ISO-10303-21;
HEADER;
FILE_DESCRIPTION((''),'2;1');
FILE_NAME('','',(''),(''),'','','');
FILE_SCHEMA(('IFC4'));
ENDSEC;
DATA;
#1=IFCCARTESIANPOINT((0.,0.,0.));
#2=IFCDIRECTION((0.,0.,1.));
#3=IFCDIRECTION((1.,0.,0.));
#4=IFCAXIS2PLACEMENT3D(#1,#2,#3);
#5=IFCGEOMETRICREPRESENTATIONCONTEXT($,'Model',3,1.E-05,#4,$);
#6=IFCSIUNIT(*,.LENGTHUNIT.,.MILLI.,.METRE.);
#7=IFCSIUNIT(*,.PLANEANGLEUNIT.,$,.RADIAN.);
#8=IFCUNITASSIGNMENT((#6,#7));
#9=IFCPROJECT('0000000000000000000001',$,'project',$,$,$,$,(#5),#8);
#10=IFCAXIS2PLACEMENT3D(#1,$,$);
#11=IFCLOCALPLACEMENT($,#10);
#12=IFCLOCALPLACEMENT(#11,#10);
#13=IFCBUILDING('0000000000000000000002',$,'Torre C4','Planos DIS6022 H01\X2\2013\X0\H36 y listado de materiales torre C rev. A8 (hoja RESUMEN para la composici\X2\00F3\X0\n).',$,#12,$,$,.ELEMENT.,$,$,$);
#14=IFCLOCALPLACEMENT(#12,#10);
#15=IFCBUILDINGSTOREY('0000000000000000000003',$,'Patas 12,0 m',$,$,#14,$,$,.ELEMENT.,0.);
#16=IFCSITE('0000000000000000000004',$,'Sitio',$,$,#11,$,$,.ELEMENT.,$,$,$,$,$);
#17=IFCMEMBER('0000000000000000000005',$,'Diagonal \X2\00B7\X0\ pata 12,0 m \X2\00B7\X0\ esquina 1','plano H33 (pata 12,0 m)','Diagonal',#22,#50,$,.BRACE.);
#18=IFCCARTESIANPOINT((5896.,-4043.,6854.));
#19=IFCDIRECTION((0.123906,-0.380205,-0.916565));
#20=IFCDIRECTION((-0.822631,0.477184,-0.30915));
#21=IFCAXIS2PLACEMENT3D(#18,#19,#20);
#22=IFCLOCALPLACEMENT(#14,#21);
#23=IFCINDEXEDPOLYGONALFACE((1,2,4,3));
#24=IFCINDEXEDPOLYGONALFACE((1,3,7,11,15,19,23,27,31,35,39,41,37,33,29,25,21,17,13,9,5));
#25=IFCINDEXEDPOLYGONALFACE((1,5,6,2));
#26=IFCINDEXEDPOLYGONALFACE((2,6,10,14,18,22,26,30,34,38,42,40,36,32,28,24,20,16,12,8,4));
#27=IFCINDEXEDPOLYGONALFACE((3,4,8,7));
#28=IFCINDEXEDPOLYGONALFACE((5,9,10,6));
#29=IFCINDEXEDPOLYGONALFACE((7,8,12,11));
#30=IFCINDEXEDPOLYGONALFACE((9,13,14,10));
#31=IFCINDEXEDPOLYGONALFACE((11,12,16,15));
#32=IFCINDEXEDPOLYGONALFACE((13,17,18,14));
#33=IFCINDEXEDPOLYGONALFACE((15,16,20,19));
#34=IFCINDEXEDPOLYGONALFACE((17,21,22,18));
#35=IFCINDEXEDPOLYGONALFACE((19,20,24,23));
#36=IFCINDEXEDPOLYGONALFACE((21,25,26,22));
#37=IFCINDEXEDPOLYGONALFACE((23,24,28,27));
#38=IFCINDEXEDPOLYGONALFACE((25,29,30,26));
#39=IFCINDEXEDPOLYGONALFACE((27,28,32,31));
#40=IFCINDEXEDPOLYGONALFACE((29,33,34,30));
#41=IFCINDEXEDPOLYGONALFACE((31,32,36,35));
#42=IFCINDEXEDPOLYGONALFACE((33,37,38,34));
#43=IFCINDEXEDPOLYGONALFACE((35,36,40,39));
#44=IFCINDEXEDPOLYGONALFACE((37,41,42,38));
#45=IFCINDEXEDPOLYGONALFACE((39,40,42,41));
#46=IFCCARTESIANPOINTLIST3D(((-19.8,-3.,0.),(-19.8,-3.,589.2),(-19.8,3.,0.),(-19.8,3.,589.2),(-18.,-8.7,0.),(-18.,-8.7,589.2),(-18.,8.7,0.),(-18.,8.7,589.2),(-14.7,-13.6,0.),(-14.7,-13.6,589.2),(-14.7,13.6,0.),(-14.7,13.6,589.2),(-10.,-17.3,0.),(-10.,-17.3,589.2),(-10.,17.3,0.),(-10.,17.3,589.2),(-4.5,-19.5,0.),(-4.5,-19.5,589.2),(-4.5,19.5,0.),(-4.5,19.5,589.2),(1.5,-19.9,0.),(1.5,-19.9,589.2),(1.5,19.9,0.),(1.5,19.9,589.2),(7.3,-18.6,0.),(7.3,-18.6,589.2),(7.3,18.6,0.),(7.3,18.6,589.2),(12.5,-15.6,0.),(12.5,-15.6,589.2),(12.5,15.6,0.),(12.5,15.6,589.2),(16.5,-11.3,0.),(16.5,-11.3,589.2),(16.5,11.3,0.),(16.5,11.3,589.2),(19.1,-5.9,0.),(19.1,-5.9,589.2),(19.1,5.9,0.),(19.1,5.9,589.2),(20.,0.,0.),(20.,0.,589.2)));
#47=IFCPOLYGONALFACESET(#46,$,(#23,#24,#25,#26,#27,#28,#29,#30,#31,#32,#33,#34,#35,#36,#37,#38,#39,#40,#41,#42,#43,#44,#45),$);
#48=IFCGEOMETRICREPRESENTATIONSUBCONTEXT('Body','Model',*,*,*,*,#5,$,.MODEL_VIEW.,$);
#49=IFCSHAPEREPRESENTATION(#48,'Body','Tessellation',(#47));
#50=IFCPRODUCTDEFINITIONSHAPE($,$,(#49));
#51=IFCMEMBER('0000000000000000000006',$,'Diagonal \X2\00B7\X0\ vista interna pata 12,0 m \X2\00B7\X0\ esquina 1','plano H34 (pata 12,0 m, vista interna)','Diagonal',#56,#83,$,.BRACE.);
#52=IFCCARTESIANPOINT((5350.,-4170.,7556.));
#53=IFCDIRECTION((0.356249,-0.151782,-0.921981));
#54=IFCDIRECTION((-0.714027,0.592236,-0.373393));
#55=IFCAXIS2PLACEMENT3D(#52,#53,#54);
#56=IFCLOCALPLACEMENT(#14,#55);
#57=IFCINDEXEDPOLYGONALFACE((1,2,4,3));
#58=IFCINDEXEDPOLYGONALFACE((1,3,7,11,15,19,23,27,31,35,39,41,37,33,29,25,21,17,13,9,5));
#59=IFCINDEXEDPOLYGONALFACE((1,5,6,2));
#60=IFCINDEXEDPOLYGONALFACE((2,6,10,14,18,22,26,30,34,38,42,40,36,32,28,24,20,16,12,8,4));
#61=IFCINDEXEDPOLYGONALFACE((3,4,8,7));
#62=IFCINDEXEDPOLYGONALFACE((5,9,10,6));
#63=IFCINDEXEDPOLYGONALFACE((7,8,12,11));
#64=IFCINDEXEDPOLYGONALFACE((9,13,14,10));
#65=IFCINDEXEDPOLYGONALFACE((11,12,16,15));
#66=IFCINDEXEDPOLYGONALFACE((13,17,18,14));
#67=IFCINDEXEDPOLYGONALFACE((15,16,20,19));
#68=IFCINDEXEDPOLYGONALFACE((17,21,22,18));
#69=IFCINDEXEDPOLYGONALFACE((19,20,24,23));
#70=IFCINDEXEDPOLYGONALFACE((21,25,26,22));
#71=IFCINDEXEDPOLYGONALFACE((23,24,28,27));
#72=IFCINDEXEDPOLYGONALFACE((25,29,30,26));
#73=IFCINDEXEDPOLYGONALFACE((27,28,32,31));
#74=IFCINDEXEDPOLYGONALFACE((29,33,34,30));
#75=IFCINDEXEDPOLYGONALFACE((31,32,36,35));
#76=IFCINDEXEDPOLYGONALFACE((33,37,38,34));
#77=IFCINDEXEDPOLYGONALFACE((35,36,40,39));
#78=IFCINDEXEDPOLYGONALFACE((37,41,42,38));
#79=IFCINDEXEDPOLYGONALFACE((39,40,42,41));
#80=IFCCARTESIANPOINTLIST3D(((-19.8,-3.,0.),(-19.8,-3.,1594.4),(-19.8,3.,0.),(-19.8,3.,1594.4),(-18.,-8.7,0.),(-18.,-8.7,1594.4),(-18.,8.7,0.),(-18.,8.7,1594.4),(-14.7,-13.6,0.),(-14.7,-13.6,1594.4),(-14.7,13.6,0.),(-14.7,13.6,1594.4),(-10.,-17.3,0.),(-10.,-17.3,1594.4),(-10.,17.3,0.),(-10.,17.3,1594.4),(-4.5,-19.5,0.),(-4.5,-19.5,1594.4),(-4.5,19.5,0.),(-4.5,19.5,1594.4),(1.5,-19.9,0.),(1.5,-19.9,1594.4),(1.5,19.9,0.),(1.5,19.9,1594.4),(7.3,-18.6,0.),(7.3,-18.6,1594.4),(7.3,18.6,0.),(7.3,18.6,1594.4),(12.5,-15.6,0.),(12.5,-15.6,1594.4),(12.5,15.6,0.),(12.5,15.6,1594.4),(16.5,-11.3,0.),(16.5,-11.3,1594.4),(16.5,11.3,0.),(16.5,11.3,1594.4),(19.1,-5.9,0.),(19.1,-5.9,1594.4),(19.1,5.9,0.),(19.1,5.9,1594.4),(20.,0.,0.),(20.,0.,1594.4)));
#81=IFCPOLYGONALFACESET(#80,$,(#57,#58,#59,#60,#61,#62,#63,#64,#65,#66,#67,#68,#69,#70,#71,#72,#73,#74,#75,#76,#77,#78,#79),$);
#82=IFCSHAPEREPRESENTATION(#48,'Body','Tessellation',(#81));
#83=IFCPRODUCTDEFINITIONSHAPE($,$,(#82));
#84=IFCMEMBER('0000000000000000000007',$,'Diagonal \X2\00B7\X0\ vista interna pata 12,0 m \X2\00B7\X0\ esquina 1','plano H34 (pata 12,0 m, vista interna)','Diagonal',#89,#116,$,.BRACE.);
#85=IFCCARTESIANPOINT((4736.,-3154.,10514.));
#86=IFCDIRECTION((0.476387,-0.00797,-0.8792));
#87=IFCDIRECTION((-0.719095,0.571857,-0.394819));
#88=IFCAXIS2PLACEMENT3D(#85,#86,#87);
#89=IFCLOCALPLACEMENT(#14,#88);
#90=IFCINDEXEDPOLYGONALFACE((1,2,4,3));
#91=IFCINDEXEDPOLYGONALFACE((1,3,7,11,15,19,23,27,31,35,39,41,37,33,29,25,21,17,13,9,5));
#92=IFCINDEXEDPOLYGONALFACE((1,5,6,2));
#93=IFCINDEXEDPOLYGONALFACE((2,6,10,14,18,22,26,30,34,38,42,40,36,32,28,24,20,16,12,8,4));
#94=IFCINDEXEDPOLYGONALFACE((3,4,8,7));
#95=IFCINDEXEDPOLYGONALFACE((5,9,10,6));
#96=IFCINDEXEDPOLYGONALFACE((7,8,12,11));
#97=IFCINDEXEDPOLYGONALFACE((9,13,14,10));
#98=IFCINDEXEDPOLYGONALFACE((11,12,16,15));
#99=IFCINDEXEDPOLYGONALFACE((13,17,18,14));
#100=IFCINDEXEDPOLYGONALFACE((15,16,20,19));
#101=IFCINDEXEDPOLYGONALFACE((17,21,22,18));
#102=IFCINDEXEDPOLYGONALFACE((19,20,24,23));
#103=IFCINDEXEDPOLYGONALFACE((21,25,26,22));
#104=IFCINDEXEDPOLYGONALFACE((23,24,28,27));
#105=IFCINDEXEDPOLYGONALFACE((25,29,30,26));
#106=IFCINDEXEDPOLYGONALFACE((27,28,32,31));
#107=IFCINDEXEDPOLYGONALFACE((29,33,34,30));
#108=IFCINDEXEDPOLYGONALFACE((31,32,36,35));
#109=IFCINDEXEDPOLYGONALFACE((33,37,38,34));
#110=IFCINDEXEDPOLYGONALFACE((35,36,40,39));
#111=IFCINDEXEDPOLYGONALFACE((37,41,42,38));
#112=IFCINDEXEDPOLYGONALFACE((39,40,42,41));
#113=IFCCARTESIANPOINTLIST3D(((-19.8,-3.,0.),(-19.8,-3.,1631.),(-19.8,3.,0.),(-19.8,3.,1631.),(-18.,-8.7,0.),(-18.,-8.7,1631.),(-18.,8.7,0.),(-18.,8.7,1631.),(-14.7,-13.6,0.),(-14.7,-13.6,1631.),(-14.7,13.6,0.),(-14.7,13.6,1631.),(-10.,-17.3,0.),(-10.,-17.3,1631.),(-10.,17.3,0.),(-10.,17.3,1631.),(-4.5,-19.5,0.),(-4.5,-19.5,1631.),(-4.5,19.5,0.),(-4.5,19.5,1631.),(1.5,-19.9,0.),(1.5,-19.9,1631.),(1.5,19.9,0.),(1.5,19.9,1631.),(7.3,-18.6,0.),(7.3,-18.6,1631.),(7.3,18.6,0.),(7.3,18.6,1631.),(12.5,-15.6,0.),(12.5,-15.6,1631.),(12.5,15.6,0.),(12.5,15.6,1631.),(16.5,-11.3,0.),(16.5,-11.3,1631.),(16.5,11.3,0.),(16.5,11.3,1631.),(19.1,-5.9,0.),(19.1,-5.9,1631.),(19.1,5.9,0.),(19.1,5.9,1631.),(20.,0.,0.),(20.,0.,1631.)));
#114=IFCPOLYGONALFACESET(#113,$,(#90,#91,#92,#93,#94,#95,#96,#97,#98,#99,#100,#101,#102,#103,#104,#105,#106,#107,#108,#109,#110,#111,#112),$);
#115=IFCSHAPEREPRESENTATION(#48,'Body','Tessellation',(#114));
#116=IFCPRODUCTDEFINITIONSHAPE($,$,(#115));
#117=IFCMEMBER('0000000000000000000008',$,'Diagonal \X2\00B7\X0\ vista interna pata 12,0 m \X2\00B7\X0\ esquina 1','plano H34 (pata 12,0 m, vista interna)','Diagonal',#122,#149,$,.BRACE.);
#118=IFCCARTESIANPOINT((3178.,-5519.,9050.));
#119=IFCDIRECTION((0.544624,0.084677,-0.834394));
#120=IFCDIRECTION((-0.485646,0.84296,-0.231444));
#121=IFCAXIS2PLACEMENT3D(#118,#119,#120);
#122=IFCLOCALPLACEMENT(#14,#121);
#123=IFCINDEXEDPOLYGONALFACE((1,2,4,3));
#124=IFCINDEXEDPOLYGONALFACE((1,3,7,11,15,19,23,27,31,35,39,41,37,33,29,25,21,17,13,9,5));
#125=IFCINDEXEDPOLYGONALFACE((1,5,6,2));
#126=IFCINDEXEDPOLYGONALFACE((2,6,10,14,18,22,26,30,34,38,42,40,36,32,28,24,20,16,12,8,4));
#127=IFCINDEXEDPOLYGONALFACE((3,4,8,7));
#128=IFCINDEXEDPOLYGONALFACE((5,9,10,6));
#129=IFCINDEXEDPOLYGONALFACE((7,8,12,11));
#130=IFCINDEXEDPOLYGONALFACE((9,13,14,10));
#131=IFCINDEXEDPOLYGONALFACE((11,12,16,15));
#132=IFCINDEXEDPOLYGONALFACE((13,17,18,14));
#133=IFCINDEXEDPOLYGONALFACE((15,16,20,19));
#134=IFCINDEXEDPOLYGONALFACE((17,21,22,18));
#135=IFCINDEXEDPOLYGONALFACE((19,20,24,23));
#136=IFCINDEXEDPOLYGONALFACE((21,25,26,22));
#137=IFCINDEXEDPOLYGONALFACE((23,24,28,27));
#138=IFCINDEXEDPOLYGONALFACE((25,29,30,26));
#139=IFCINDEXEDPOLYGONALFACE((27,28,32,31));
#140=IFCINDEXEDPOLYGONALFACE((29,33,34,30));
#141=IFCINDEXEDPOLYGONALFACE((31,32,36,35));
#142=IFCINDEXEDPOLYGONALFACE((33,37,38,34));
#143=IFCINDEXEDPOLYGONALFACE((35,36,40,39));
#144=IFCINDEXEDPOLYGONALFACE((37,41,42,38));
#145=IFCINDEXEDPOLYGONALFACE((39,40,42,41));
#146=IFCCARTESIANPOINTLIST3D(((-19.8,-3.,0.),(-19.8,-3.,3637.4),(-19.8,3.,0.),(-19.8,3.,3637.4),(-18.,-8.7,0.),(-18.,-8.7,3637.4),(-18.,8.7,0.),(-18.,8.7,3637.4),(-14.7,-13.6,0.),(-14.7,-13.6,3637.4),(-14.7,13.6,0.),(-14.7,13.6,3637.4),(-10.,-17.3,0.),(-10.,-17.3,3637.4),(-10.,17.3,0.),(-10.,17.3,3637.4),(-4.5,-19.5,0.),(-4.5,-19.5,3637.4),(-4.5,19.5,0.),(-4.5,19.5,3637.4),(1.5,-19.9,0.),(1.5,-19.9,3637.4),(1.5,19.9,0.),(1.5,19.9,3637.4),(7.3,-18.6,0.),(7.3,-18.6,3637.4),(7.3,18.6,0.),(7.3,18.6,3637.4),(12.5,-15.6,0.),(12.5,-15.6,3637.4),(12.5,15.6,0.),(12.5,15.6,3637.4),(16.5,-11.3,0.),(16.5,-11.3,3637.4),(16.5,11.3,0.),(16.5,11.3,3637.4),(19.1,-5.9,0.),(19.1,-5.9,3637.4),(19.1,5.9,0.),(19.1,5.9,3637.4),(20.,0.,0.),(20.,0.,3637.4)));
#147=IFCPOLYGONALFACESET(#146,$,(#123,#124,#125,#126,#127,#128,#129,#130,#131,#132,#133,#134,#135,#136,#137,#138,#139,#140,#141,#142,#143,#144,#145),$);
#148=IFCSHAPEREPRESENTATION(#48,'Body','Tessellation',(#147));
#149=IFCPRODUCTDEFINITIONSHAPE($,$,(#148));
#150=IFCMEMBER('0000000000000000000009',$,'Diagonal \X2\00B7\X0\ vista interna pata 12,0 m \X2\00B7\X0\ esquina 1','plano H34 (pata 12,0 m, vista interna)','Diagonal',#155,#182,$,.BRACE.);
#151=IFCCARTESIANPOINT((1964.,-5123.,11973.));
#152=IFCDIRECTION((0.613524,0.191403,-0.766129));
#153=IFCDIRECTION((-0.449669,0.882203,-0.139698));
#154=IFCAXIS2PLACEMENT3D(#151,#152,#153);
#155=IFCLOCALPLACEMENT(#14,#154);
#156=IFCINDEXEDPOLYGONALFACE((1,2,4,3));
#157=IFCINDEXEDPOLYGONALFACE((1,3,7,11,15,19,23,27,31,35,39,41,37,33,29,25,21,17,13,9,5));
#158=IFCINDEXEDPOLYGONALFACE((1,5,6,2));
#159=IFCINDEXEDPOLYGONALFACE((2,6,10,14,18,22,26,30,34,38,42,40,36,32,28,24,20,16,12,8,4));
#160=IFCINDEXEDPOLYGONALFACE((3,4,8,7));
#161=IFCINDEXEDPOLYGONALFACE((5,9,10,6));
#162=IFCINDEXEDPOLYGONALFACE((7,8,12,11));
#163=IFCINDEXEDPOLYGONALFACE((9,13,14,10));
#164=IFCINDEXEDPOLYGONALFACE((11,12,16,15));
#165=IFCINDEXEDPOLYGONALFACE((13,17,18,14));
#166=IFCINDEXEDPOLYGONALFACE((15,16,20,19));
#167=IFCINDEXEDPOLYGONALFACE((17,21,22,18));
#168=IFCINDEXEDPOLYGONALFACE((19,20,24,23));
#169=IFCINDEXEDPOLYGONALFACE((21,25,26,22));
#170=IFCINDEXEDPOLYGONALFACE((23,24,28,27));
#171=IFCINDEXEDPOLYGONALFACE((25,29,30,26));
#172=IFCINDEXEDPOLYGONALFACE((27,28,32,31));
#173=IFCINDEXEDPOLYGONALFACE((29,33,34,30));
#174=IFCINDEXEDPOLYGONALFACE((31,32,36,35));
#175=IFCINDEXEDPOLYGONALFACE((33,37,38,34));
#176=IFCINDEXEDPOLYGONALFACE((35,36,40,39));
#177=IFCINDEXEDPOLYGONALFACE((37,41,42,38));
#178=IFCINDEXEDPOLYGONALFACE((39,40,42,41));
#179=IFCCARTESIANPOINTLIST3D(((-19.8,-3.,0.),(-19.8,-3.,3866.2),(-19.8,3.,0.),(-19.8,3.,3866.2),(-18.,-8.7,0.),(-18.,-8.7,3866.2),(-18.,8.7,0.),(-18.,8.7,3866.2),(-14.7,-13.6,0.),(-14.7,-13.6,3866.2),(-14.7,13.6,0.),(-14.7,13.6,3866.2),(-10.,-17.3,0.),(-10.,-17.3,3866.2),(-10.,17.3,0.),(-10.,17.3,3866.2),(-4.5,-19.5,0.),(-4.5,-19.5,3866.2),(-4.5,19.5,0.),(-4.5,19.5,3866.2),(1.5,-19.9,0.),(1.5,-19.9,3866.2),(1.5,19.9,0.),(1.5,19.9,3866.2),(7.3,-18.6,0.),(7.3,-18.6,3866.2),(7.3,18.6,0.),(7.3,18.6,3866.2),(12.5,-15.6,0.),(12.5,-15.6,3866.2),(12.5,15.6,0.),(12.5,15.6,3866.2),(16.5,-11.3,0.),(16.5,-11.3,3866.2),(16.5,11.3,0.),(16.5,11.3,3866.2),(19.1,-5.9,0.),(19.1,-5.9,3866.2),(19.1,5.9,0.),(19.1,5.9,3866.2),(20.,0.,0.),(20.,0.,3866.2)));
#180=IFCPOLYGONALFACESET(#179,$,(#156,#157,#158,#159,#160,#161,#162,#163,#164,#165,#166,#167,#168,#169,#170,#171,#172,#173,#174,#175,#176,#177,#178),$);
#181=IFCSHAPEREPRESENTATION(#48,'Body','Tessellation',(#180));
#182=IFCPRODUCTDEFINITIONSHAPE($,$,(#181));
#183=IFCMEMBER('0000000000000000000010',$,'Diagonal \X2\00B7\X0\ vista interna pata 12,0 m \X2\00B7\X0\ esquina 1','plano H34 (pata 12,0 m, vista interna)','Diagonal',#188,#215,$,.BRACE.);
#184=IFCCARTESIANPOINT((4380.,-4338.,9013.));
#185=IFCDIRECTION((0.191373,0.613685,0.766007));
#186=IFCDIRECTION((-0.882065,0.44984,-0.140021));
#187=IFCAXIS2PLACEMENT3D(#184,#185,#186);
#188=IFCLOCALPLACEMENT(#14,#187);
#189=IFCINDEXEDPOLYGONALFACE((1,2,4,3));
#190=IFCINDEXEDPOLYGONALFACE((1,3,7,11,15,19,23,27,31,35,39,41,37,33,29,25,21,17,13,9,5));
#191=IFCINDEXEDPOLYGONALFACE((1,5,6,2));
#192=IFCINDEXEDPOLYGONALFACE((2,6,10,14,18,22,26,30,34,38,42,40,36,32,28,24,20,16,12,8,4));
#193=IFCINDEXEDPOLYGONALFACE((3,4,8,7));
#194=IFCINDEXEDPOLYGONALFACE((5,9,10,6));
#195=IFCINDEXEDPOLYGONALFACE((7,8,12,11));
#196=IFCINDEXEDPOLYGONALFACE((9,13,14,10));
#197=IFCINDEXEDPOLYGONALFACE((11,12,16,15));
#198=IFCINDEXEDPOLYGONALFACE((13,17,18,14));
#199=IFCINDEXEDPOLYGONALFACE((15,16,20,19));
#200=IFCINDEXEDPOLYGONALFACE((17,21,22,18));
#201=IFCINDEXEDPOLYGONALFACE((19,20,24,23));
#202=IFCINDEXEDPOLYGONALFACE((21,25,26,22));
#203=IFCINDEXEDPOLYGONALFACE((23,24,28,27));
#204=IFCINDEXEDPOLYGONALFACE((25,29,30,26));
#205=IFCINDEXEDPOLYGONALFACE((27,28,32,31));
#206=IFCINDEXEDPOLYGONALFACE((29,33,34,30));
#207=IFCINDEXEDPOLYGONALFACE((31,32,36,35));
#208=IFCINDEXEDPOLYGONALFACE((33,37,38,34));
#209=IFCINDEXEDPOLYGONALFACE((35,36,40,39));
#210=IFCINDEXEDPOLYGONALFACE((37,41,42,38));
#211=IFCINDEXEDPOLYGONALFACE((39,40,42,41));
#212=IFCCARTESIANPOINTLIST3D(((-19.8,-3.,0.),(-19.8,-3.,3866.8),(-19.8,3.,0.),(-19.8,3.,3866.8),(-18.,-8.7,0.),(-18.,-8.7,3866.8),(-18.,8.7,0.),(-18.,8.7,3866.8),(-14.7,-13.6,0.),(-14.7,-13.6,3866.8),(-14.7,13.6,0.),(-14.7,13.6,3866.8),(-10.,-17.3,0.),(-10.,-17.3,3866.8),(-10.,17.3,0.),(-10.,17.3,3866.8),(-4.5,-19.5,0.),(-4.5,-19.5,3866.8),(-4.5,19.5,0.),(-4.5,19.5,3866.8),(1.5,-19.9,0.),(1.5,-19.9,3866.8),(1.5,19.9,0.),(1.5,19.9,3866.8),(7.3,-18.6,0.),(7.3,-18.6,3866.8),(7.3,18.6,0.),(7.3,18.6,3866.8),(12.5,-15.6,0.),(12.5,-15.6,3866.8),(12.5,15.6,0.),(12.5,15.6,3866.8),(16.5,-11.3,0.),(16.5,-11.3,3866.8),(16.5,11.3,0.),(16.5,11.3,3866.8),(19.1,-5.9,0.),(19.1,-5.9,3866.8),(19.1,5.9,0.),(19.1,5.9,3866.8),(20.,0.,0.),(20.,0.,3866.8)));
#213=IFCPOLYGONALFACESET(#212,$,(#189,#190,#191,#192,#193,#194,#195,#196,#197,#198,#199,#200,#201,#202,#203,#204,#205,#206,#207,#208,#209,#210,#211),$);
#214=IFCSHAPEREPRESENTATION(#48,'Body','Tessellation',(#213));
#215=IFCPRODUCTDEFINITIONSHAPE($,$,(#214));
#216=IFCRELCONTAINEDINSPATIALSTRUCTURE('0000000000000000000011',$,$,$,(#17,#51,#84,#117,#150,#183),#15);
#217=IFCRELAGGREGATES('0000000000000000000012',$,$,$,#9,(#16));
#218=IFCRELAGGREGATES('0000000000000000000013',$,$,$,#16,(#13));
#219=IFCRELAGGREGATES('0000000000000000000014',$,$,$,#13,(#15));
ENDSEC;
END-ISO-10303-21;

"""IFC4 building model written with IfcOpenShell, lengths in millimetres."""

from ifc_helpers import new_model, si_unit, frame, origin, origin_with_axes, place, context, subcontext, project, spatial, circle, extrude, element, save


model = new_model("IFC4")

# Units and contexts
model_context = context("Model", 3, precision=1e-05, world=origin_with_axes())
body_context = subcontext(model_context, "Body", "Model", "MODEL_VIEW")
ifc_project = project(units=[si_unit("LENGTHUNIT", "METRE", prefix="MILLI"), si_unit("PLANEANGLEUNIT", "RADIAN")], contexts=[model_context])

# Site, building, storey
site_placement = place(None, origin())
site = spatial("IfcSite", under=ifc_project, at=site_placement, Name="Sitio", CompositionType="ELEMENT")
building_placement = place(site_placement, origin())
building = spatial("IfcBuilding", under=site, at=building_placement, Name="Torre C4", Description="Planos DIS6022 H01–H36 y listado de materiales torre C rev. A8 (hoja RESUMEN para la composición).", CompositionType="ELEMENT")
storey_placement = place(building_placement, origin())
storey = spatial("IfcBuildingStorey", under=building, at=storey_placement, Name="Patas 12,0 m", CompositionType="ELEMENT", Elevation=0.0)

# Members
member_1_placement = place(storey_placement, frame((5896.0, -4043.0, 6854.0), z_axis=(0.123906, -0.380205, -0.916565), x_axis=(-0.822631, 0.477184, -0.30915)))
element("IfcMember", 1, at=member_1_placement, inside=storey, Name="Diagonal · pata 12,0 m · esquina 1", Description="plano H33 (pata 12,0 m)", ObjectType="Diagonal", PredefinedType="BRACE", context=body_context, shape_type="SweptSolid", body=[
    extrude(circle(Radius=20.0), None, (0.0, 0.0, 1.0), 589.2),
])
member_2_placement = place(storey_placement, frame((5350.0, -4170.0, 7556.0), z_axis=(0.356249, -0.151782, -0.921981), x_axis=(-0.714027, 0.592236, -0.373393)))
element("IfcMember", 2, at=member_2_placement, inside=storey, Name="Diagonal · vista interna pata 12,0 m · esquina 1", Description="plano H34 (pata 12,0 m, vista interna)", ObjectType="Diagonal", PredefinedType="BRACE", context=body_context, shape_type="SweptSolid", body=[
    extrude(circle(Radius=20.0), None, (0.0, 0.0, 1.0), 1594.4),
])
member_3_placement = place(storey_placement, frame((4736.0, -3154.0, 10514.0), z_axis=(0.476387, -0.00797, -0.8792), x_axis=(-0.719095, 0.571857, -0.394819)))
element("IfcMember", 3, at=member_3_placement, inside=storey, Name="Diagonal · vista interna pata 12,0 m · esquina 1", Description="plano H34 (pata 12,0 m, vista interna)", ObjectType="Diagonal", PredefinedType="BRACE", context=body_context, shape_type="SweptSolid", body=[
    extrude(circle(Radius=20.0), None, (0.0, 0.0, 1.0), 1631.0),
])
member_4_placement = place(storey_placement, frame((3178.0, -5519.0, 9050.0), z_axis=(0.544624, 0.084677, -0.834394), x_axis=(-0.485646, 0.84296, -0.231444)))
element("IfcMember", 4, at=member_4_placement, inside=storey, Name="Diagonal · vista interna pata 12,0 m · esquina 1", Description="plano H34 (pata 12,0 m, vista interna)", ObjectType="Diagonal", PredefinedType="BRACE", context=body_context, shape_type="SweptSolid", body=[
    extrude(circle(Radius=20.0), None, (0.0, 0.0, 1.0), 3637.4),
])
member_5_placement = place(storey_placement, frame((1964.0, -5123.0, 11973.0), z_axis=(0.613524, 0.191403, -0.766129), x_axis=(-0.449669, 0.882203, -0.139698)))
element("IfcMember", 5, at=member_5_placement, inside=storey, Name="Diagonal · vista interna pata 12,0 m · esquina 1", Description="plano H34 (pata 12,0 m, vista interna)", ObjectType="Diagonal", PredefinedType="BRACE", context=body_context, shape_type="SweptSolid", body=[
    extrude(circle(Radius=20.0), None, (0.0, 0.0, 1.0), 3866.2),
])
member_6_placement = place(storey_placement, frame((4380.0, -4338.0, 9013.0), z_axis=(0.191373, 0.613685, 0.766007), x_axis=(-0.882065, 0.44984, -0.140021)))
element("IfcMember", 6, at=member_6_placement, inside=storey, Name="Diagonal · vista interna pata 12,0 m · esquina 1", Description="plano H34 (pata 12,0 m, vista interna)", ObjectType="Diagonal", PredefinedType="BRACE", context=body_context, shape_type="SweptSolid", body=[
    extrude(circle(Radius=20.0), None, (0.0, 0.0, 1.0), 3866.8),
])

save(model, "model.ifc")
